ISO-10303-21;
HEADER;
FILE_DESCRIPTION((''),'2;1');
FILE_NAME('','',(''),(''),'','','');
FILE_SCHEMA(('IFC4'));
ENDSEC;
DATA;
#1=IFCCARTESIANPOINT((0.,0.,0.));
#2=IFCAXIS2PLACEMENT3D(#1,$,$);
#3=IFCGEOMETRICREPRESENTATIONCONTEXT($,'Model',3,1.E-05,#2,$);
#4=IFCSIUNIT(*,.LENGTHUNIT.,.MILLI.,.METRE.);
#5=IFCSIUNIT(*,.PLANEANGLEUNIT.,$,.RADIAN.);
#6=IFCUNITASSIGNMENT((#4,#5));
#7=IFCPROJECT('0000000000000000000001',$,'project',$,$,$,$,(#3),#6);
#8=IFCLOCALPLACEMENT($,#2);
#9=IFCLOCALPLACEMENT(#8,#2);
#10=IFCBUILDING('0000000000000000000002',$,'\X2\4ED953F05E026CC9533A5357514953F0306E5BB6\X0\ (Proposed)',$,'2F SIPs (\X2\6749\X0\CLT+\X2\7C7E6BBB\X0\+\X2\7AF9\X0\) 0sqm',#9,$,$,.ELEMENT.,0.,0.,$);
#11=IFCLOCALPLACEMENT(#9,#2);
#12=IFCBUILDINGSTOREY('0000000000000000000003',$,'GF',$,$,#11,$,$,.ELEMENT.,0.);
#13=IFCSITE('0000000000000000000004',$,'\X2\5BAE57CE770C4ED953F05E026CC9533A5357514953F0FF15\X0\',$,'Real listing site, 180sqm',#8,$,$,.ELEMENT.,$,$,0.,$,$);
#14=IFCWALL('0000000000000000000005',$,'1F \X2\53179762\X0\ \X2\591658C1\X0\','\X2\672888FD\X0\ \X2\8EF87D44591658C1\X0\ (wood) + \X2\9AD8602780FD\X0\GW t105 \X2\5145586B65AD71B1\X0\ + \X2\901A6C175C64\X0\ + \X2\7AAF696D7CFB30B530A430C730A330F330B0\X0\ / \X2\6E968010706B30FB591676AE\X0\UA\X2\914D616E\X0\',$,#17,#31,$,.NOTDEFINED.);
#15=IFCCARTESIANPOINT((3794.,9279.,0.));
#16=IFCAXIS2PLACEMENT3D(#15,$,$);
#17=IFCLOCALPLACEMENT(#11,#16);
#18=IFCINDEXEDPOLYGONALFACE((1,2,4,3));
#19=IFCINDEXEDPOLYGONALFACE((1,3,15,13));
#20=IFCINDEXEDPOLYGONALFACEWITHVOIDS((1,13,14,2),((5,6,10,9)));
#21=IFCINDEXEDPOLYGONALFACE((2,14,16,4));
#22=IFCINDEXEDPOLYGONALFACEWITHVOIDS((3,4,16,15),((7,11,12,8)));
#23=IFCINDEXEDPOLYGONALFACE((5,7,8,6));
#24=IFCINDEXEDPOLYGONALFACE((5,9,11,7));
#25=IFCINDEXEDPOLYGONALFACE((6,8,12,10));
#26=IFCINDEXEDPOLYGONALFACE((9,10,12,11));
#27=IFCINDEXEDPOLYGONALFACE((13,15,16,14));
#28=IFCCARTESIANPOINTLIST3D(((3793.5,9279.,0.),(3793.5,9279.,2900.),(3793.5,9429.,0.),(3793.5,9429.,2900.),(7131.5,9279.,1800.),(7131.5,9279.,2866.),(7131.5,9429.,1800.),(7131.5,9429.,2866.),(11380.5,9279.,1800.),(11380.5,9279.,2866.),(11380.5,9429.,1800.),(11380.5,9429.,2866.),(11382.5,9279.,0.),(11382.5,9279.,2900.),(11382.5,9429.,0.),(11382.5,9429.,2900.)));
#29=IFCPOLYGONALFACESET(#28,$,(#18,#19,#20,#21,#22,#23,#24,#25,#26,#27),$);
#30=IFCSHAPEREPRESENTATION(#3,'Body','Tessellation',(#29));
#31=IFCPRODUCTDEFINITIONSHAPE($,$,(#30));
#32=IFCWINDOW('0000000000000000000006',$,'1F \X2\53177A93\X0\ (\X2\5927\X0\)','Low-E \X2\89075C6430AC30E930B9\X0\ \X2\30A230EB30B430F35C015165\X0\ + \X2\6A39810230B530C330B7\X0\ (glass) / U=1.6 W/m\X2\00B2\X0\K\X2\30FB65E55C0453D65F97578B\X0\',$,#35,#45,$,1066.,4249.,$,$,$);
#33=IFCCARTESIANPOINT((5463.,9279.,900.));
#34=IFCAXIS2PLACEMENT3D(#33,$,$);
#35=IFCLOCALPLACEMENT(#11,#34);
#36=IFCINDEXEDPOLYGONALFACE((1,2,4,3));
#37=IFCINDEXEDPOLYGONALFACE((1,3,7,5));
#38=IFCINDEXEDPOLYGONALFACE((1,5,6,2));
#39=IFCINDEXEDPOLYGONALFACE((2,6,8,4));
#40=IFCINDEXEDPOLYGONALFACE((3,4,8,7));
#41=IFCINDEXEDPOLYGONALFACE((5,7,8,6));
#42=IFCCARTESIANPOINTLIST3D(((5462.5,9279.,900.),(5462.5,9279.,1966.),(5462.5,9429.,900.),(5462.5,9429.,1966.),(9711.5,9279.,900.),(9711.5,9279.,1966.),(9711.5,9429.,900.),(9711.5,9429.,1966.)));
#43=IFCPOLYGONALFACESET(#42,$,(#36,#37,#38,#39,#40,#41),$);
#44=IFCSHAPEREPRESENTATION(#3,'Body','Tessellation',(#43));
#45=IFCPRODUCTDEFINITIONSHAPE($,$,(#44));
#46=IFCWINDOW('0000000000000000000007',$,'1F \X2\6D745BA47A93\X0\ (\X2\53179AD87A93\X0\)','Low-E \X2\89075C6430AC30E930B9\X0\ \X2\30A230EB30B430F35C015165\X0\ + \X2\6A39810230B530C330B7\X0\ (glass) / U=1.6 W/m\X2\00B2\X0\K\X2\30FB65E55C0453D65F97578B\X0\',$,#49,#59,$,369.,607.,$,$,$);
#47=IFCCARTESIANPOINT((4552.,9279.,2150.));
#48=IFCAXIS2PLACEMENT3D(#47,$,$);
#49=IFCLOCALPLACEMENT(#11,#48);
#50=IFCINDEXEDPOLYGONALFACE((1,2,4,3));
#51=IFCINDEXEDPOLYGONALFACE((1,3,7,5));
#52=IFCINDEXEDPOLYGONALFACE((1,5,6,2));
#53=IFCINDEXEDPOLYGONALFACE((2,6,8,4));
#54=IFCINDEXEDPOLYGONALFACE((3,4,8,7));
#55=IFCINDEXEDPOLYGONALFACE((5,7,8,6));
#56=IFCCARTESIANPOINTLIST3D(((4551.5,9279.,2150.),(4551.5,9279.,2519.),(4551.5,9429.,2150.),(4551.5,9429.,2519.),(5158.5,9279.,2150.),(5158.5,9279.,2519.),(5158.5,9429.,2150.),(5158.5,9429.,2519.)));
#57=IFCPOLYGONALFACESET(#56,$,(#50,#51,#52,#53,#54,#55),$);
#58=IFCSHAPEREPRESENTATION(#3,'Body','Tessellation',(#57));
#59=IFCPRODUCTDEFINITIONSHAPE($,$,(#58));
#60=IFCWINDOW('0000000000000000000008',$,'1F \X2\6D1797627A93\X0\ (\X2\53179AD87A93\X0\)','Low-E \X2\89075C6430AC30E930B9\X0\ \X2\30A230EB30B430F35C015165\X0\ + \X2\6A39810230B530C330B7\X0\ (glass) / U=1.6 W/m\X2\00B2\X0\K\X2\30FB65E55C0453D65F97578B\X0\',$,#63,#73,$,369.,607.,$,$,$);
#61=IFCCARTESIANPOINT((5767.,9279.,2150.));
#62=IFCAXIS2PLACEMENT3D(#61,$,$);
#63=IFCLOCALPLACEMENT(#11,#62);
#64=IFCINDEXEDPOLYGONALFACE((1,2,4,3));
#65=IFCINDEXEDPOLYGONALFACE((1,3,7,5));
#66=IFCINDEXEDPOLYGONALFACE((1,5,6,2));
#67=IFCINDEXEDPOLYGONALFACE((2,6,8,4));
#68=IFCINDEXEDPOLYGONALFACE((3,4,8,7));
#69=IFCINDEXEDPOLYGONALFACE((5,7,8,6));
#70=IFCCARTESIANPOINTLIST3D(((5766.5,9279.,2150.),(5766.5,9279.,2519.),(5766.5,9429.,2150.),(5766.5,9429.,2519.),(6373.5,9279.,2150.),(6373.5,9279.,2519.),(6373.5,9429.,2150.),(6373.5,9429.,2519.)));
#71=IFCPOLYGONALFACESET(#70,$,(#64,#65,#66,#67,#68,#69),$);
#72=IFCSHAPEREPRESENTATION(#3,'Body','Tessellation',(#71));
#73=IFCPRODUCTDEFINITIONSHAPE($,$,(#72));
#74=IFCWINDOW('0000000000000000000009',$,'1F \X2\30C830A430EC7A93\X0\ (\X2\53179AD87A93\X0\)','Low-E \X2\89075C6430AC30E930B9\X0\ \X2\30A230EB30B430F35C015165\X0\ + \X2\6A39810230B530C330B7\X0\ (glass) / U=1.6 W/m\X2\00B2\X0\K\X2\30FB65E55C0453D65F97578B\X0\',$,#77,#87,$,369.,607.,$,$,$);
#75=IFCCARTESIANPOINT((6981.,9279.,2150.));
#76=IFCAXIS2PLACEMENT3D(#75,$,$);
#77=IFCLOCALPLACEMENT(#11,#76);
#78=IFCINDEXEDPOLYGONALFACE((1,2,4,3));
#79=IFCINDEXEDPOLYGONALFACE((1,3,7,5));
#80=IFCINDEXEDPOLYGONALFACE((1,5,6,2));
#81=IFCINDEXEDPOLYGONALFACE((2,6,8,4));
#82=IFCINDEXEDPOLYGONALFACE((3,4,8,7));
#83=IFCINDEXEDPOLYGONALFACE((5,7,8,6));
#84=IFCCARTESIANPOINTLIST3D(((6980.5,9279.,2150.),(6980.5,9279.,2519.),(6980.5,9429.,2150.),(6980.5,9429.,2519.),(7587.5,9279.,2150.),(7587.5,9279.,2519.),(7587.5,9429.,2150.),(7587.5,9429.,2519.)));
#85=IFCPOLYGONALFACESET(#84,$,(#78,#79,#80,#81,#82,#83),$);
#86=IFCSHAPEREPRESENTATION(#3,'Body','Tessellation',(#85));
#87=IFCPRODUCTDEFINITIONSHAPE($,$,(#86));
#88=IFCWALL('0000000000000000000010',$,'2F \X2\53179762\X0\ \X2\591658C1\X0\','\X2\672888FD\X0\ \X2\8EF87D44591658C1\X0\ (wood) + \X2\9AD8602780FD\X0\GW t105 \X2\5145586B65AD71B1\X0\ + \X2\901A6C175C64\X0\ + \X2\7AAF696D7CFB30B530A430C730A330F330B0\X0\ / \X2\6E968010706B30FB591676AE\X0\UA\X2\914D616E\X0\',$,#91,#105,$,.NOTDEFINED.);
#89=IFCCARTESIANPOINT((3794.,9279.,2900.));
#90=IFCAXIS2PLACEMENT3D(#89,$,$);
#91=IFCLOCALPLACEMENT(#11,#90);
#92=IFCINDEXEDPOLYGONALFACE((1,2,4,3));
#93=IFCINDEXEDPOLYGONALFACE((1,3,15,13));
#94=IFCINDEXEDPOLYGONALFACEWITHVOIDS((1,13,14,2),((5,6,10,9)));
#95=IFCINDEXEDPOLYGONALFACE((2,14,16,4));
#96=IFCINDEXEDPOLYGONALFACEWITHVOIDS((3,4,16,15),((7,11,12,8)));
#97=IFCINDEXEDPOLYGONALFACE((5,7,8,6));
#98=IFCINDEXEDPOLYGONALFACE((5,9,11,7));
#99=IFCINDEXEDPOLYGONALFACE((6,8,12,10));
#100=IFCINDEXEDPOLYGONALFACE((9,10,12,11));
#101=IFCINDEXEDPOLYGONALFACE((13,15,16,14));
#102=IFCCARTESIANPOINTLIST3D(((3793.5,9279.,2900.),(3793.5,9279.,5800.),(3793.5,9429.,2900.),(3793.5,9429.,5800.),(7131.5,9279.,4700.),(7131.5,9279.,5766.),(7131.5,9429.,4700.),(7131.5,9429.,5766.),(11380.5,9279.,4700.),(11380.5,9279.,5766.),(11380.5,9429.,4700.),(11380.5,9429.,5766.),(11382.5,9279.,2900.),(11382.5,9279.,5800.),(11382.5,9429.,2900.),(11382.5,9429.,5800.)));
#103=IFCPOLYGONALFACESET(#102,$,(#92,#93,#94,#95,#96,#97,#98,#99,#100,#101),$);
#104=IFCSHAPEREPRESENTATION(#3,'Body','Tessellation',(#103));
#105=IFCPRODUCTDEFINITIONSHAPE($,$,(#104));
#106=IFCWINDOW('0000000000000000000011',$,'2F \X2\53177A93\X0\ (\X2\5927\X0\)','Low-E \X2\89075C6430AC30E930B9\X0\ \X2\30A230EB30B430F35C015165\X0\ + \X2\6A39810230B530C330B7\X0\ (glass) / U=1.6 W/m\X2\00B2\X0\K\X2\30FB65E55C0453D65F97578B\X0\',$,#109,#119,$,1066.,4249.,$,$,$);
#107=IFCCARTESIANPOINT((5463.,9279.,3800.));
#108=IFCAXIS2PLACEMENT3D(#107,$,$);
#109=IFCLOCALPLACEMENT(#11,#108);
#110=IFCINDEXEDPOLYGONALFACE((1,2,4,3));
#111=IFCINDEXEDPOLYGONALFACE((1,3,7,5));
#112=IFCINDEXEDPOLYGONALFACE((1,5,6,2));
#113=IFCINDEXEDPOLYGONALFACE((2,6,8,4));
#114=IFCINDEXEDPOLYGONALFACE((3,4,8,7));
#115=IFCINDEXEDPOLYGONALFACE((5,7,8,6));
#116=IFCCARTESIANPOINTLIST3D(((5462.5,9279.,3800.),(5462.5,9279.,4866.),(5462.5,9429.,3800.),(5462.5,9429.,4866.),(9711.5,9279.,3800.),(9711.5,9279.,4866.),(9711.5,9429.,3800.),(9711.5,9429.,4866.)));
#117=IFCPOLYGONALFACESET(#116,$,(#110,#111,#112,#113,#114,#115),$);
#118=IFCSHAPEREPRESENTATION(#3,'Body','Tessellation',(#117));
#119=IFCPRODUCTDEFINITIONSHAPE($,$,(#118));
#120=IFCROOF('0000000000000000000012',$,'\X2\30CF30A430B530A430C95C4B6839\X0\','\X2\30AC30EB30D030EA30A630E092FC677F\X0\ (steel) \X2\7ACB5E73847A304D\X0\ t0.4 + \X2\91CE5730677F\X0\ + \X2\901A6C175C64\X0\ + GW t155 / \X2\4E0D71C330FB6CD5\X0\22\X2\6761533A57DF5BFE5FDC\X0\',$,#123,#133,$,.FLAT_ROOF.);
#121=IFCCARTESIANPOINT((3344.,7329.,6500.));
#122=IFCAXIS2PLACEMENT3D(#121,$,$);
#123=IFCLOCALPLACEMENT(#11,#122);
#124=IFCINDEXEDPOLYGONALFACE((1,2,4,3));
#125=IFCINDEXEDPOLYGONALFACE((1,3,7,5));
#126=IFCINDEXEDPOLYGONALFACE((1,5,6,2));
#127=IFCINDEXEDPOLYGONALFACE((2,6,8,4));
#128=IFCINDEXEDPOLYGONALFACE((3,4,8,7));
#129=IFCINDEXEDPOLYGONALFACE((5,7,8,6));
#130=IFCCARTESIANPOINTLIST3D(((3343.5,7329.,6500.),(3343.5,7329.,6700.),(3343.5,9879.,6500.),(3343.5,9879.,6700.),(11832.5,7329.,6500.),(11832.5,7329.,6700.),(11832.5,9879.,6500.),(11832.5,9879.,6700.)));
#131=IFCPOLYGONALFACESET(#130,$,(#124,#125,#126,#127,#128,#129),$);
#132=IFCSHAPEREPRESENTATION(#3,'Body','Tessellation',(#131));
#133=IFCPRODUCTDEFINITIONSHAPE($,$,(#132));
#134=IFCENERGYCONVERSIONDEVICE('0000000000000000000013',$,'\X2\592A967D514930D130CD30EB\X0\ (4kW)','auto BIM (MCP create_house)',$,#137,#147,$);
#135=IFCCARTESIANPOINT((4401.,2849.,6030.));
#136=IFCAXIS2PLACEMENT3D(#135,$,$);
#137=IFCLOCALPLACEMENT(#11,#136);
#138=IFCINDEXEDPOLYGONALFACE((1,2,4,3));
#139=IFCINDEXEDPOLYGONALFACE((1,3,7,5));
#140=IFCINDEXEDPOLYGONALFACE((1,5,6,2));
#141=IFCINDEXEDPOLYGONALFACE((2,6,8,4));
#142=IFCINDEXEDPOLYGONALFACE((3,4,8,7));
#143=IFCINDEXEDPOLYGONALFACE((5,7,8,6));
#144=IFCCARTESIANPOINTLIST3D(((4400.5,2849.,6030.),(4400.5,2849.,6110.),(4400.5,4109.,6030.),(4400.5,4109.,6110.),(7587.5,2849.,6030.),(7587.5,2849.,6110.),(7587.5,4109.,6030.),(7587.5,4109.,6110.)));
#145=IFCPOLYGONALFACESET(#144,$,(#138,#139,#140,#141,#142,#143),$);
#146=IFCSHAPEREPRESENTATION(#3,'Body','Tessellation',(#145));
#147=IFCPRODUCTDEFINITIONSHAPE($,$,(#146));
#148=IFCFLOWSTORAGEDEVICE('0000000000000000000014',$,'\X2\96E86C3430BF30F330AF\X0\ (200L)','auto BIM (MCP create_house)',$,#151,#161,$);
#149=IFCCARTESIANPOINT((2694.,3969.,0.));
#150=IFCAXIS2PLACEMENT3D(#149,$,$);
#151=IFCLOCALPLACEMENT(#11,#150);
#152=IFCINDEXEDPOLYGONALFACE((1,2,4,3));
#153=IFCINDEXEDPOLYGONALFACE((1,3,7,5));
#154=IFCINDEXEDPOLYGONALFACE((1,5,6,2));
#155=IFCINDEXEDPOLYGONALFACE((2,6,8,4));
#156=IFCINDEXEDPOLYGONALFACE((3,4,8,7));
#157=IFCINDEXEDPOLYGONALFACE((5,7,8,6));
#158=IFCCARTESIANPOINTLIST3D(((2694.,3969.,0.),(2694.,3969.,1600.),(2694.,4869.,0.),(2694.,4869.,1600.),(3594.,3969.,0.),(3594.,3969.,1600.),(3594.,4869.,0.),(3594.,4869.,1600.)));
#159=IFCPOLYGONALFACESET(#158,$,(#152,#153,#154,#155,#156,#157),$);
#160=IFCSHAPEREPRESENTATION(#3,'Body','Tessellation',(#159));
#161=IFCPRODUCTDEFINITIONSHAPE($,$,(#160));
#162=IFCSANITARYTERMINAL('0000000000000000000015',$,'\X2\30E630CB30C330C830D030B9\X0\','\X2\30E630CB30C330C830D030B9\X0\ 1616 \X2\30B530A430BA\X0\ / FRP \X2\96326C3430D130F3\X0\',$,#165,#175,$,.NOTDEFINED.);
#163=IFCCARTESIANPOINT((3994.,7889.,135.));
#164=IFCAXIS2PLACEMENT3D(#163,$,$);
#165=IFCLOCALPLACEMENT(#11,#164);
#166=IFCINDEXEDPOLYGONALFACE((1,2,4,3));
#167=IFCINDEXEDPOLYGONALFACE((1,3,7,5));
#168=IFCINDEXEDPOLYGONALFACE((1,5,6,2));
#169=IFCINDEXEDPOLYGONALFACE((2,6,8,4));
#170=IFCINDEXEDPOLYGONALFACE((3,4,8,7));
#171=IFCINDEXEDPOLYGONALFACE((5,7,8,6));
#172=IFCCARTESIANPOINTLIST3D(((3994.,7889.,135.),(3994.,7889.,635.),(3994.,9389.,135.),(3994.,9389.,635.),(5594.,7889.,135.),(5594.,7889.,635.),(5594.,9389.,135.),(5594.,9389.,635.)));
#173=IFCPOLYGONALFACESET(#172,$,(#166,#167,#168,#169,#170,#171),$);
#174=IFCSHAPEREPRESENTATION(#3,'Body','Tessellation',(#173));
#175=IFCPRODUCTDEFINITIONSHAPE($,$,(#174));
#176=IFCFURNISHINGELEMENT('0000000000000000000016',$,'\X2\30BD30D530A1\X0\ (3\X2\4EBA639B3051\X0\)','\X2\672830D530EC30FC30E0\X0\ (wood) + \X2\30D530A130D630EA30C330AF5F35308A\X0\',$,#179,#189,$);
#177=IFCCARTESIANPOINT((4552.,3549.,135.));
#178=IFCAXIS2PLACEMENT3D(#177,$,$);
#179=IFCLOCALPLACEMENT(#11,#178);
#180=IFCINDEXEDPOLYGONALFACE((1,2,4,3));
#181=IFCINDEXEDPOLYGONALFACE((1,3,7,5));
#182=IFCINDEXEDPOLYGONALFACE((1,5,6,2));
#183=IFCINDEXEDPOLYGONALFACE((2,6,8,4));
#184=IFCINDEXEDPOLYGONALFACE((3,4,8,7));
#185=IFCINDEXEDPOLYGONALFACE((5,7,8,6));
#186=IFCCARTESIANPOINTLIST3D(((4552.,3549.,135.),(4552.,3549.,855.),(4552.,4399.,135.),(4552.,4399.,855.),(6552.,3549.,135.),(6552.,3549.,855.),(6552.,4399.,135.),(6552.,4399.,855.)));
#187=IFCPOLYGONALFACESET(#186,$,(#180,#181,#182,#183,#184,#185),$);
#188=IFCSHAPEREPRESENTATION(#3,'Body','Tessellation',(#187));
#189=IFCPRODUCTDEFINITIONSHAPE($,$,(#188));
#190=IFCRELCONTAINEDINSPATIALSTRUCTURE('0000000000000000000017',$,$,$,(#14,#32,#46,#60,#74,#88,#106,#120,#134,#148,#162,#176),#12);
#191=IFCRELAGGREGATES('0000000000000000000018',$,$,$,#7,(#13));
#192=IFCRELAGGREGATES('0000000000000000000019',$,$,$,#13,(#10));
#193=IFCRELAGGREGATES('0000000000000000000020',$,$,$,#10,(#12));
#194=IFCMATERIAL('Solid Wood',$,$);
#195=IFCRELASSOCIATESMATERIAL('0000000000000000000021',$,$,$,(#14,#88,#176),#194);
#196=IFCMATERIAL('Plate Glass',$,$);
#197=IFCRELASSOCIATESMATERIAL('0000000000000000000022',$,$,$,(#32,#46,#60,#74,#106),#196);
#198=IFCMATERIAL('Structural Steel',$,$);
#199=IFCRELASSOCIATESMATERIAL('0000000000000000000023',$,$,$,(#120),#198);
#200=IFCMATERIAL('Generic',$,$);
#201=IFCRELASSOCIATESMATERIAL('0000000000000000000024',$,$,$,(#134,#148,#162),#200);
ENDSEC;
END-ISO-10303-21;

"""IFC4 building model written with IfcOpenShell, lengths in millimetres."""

from ifc_helpers import new_model, si_unit, frame, frame_2d, origin, place, context, project, spatial, rectangle, extrude, material, element, fill, save


model = new_model("IFC4")

# Units and contexts
model_context = context("Model", 3, precision=1e-05, world=origin())
ifc_project = project(units=[si_unit("LENGTHUNIT", "METRE", prefix="MILLI"), si_unit("PLANEANGLEUNIT", "RADIAN")], contexts=[model_context])

# Site, building, storey
site_placement = place(None, origin())
site = spatial("IfcSite", under=ifc_project, at=site_placement, Name="宮城県仙台市泉区南光台５", ObjectType="Real listing site, 180sqm", CompositionType="ELEMENT", RefElevation=0.0)
building_placement = place(site_placement, origin())
building = spatial("IfcBuilding", under=site, at=building_placement, Name="仙台市泉区南光台の家 (Proposed)", ObjectType="2F SIPs (杉CLT+籾殻+竹) 0sqm", CompositionType="ELEMENT", ElevationOfRefHeight=0.0, ElevationOfTerrain=0.0)
storey_placement = place(building_placement, origin())
storey = spatial("IfcBuildingStorey", under=building, at=storey_placement, Name="GF", CompositionType="ELEMENT", Elevation=0.0)

# Wall, openings, windows
ifc_material_1 = material(Name="Solid Wood")
wall_1_placement = place(storey_placement, frame((3794.0, 9279.0, 0.0)))
wall_1 = element("IfcWall", 1, at=wall_1_placement, inside=storey, material=ifc_material_1, Name="1F 北面 外壁", Description="木製 軸組外壁 (wood) + 高性能GW t105 充填断熱 + 通気層 + 窯業系サイディング / 準耐火・外皮UA配慮", PredefinedType="NOTDEFINED", context=model_context, shape_type="SweptSolid", body=[
    extrude(rectangle(XDim=7589.0, YDim=150.0, at=frame_2d((3794.0, 75.0))), frame((3794.0, 9279.0, 0.0)), (0.0, 0.0, 1.0), 2900.0),
])
opening_1_placement = place(storey_placement, frame((5463.0, 9279.0, 900.0)))
opening_1 = element("IfcOpeningElement", 2, at=opening_1_placement, cuts=wall_1, PredefinedType="NOTDEFINED", context=model_context, shape_type="SweptSolid", body=[
    extrude(rectangle(XDim=4249.0, YDim=150.0, at=frame_2d((2124.0, 75.0))), frame((5463.0, 9279.0, 900.0)), (0.0, 0.0, 1.0), 1066.0),
])
opening_2_placement = place(storey_placement, frame((4552.0, 9279.0, 2150.0)))
opening_2 = element("IfcOpeningElement", 3, at=opening_2_placement, cuts=wall_1, PredefinedType="NOTDEFINED", context=model_context, shape_type="SweptSolid", body=[
    extrude(rectangle(XDim=607.0, YDim=150.0, at=frame_2d((303.0, 75.0))), frame((4552.0, 9279.0, 2150.0)), (0.0, 0.0, 1.0), 369.0),
])
opening_3_placement = place(storey_placement, frame((5767.0, 9279.0, 2150.0)))
opening_3 = element("IfcOpeningElement", 4, at=opening_3_placement, cuts=wall_1, PredefinedType="NOTDEFINED", context=model_context, shape_type="SweptSolid", body=[
    extrude(rectangle(XDim=607.0, YDim=150.0, at=frame_2d((303.0, 75.0))), frame((5767.0, 9279.0, 2150.0)), (0.0, 0.0, 1.0), 369.0),
])
opening_4_placement = place(storey_placement, frame((6981.0, 9279.0, 2150.0)))
opening_4 = element("IfcOpeningElement", 5, at=opening_4_placement, cuts=wall_1, PredefinedType="NOTDEFINED", context=model_context, shape_type="SweptSolid", body=[
    extrude(rectangle(XDim=607.0, YDim=150.0, at=frame_2d((303.0, 75.0))), frame((6981.0, 9279.0, 2150.0)), (0.0, 0.0, 1.0), 369.0),
])
ifc_material_2 = material(Name="Plate Glass")
window_1_placement = place(storey_placement, frame((5463.0, 9279.0, 900.0)))
window_1 = element("IfcWindow", 6, at=window_1_placement, inside=storey, material=ifc_material_2, Name="1F 北窓 (大)", Description="Low-E 複層ガラス アルゴン封入 + 樹脂サッシ (glass) / U=1.6 W/m²K・日射取得型", OverallHeight=1066.0, OverallWidth=4249.0, context=model_context, shape_type="SweptSolid", body=[
    extrude(rectangle(XDim=4249.0, YDim=150.0, at=frame_2d((2124.0, 75.0))), frame((5463.0, 9279.0, 900.0)), (0.0, 0.0, 1.0), 1066.0),
])
fill(opening_1, window_1)
window_2_placement = place(storey_placement, frame((4552.0, 9279.0, 2150.0)))
window_2 = element("IfcWindow", 7, at=window_2_placement, inside=storey, material=ifc_material_2, Name="1F 浴室窓 (北高窓)", Description="Low-E 複層ガラス アルゴン封入 + 樹脂サッシ (glass) / U=1.6 W/m²K・日射取得型", OverallHeight=369.0, OverallWidth=607.0, context=model_context, shape_type="SweptSolid", body=[
    extrude(rectangle(XDim=607.0, YDim=150.0, at=frame_2d((303.0, 75.0))), frame((4552.0, 9279.0, 2150.0)), (0.0, 0.0, 1.0), 369.0),
])
fill(opening_2, window_2)
window_3_placement = place(storey_placement, frame((5767.0, 9279.0, 2150.0)))
window_3 = element("IfcWindow", 8, at=window_3_placement, inside=storey, material=ifc_material_2, Name="1F 洗面窓 (北高窓)", Description="Low-E 複層ガラス アルゴン封入 + 樹脂サッシ (glass) / U=1.6 W/m²K・日射取得型", OverallHeight=369.0, OverallWidth=607.0, context=model_context, shape_type="SweptSolid", body=[
    extrude(rectangle(XDim=607.0, YDim=150.0, at=frame_2d((303.0, 75.0))), frame((5767.0, 9279.0, 2150.0)), (0.0, 0.0, 1.0), 369.0),
])
fill(opening_3, window_3)
window_4_placement = place(storey_placement, frame((6981.0, 9279.0, 2150.0)))
window_4 = element("IfcWindow", 9, at=window_4_placement, inside=storey, material=ifc_material_2, Name="1F トイレ窓 (北高窓)", Description="Low-E 複層ガラス アルゴン封入 + 樹脂サッシ (glass) / U=1.6 W/m²K・日射取得型", OverallHeight=369.0, OverallWidth=607.0, context=model_context, shape_type="SweptSolid", body=[
    extrude(rectangle(XDim=607.0, YDim=150.0, at=frame_2d((303.0, 75.0))), frame((6981.0, 9279.0, 2150.0)), (0.0, 0.0, 1.0), 369.0),
])
fill(opening_4, window_4)

# Wall, opening, window
wall_2_placement = place(storey_placement, frame((3794.0, 9279.0, 2900.0)))
wall_2 = element("IfcWall", 10, at=wall_2_placement, inside=storey, material=ifc_material_1, Name="2F 北面 外壁", Description="木製 軸組外壁 (wood) + 高性能GW t105 充填断熱 + 通気層 + 窯業系サイディング / 準耐火・外皮UA配慮", PredefinedType="NOTDEFINED", context=model_context, shape_type="SweptSolid", body=[
    extrude(rectangle(XDim=7589.0, YDim=150.0, at=frame_2d((3794.0, 75.0))), frame((3794.0, 9279.0, 2900.0)), (0.0, 0.0, 1.0), 2900.0),
])
opening_5_placement = place(storey_placement, frame((5463.0, 9279.0, 3800.0)))
opening_5 = element("IfcOpeningElement", 11, at=opening_5_placement, cuts=wall_2, PredefinedType="NOTDEFINED", context=model_context, shape_type="SweptSolid", body=[
    extrude(rectangle(XDim=4249.0, YDim=150.0, at=frame_2d((2124.0, 75.0))), frame((5463.0, 9279.0, 3800.0)), (0.0, 0.0, 1.0), 1066.0),
])
window_5_placement = place(storey_placement, frame((5463.0, 9279.0, 3800.0)))
window_5 = element("IfcWindow", 12, at=window_5_placement, inside=storey, material=ifc_material_2, Name="2F 北窓 (大)", Description="Low-E 複層ガラス アルゴン封入 + 樹脂サッシ (glass) / U=1.6 W/m²K・日射取得型", OverallHeight=1066.0, OverallWidth=4249.0, context=model_context, shape_type="SweptSolid", body=[
    extrude(rectangle(XDim=4249.0, YDim=150.0, at=frame_2d((2124.0, 75.0))), frame((5463.0, 9279.0, 3800.0)), (0.0, 0.0, 1.0), 1066.0),
])
fill(opening_5, window_5)

# Roof
ifc_material_3 = material(Name="Structural Steel")
roof_placement = place(storey_placement, frame((3344.0, 7329.0, 6500.0)))
element("IfcRoof", 13, at=roof_placement, inside=storey, material=ifc_material_3, Name="ハイサイド屋根", Description="ガルバリウム鋼板 (steel) 立平葺き t0.4 + 野地板 + 通気層 + GW t155 / 不燃・法22条区域対応", PredefinedType="FLAT_ROOF", context=model_context, shape_type="SweptSolid", body=[
    extrude(rectangle(XDim=8489.0, YDim=2550.0, at=frame_2d((4244.0, 1275.0))), frame((3344.0, 7329.0, 6500.0)), (0.0, 0.0, 1.0), 200.0),
])

# Energy conversion device
ifc_material_4 = material(Name="Generic")
energy_conversion_device_placement = place(storey_placement, frame((4401.0, 2849.0, 6030.0)))
element("IfcEnergyConversionDevice", 14, at=energy_conversion_device_placement, inside=storey, material=ifc_material_4, Name="太陽光パネル (4kW)", Description="auto BIM (MCP create_house)", context=model_context, shape_type="SweptSolid", body=[
    extrude(rectangle(XDim=3187.0, YDim=1260.0, at=frame_2d((1593.0, 630.0))), frame((4401.0, 2849.0, 6030.0)), (0.0, 0.0, 1.0), 80.0),
])

# Flow storage device
flow_storage_device_placement = place(storey_placement, frame((2694.0, 3969.0, 0.0)))
element("IfcFlowStorageDevice", 15, at=flow_storage_device_placement, inside=storey, material=ifc_material_4, Name="雨水タンク (200L)", Description="auto BIM (MCP create_house)", context=model_context, shape_type="SweptSolid", body=[
    extrude(rectangle(XDim=900.0, YDim=900.0, at=frame_2d((450.0, 450.0))), frame((2694.0, 3969.0, 0.0)), (0.0, 0.0, 1.0), 1600.0),
])

# Sanitary terminal
sanitary_terminal_placement = place(storey_placement, frame((3994.0, 7889.0, 135.0)))
element("IfcSanitaryTerminal", 16, at=sanitary_terminal_placement, inside=storey, material=ifc_material_4, Name="ユニットバス", Description="ユニットバス 1616 サイズ / FRP 防水パン", PredefinedType="NOTDEFINED", context=model_context, shape_type="SweptSolid", body=[
    extrude(rectangle(XDim=1600.0, YDim=1500.0, at=frame_2d((800.0, 750.0))), frame((3994.0, 7889.0, 135.0)), (0.0, 0.0, 1.0), 500.0),
])

# Furnishing element
furnishing_1_placement = place(storey_placement, frame((4552.0, 3549.0, 135.0)))
element("IfcFurnishingElement", 17, at=furnishing_1_placement, inside=storey, material=ifc_material_1, Name="ソファ (3人掛け)", Description="木フレーム (wood) + ファブリック張り", context=model_context, shape_type="SweptSolid", body=[
    extrude(rectangle(XDim=2000.0, YDim=850.0, at=frame_2d((1000.0, 425.0))), frame((4552.0, 3549.0, 135.0)), (0.0, 0.0, 1.0), 720.0),
])

save(model, "model.ifc")
